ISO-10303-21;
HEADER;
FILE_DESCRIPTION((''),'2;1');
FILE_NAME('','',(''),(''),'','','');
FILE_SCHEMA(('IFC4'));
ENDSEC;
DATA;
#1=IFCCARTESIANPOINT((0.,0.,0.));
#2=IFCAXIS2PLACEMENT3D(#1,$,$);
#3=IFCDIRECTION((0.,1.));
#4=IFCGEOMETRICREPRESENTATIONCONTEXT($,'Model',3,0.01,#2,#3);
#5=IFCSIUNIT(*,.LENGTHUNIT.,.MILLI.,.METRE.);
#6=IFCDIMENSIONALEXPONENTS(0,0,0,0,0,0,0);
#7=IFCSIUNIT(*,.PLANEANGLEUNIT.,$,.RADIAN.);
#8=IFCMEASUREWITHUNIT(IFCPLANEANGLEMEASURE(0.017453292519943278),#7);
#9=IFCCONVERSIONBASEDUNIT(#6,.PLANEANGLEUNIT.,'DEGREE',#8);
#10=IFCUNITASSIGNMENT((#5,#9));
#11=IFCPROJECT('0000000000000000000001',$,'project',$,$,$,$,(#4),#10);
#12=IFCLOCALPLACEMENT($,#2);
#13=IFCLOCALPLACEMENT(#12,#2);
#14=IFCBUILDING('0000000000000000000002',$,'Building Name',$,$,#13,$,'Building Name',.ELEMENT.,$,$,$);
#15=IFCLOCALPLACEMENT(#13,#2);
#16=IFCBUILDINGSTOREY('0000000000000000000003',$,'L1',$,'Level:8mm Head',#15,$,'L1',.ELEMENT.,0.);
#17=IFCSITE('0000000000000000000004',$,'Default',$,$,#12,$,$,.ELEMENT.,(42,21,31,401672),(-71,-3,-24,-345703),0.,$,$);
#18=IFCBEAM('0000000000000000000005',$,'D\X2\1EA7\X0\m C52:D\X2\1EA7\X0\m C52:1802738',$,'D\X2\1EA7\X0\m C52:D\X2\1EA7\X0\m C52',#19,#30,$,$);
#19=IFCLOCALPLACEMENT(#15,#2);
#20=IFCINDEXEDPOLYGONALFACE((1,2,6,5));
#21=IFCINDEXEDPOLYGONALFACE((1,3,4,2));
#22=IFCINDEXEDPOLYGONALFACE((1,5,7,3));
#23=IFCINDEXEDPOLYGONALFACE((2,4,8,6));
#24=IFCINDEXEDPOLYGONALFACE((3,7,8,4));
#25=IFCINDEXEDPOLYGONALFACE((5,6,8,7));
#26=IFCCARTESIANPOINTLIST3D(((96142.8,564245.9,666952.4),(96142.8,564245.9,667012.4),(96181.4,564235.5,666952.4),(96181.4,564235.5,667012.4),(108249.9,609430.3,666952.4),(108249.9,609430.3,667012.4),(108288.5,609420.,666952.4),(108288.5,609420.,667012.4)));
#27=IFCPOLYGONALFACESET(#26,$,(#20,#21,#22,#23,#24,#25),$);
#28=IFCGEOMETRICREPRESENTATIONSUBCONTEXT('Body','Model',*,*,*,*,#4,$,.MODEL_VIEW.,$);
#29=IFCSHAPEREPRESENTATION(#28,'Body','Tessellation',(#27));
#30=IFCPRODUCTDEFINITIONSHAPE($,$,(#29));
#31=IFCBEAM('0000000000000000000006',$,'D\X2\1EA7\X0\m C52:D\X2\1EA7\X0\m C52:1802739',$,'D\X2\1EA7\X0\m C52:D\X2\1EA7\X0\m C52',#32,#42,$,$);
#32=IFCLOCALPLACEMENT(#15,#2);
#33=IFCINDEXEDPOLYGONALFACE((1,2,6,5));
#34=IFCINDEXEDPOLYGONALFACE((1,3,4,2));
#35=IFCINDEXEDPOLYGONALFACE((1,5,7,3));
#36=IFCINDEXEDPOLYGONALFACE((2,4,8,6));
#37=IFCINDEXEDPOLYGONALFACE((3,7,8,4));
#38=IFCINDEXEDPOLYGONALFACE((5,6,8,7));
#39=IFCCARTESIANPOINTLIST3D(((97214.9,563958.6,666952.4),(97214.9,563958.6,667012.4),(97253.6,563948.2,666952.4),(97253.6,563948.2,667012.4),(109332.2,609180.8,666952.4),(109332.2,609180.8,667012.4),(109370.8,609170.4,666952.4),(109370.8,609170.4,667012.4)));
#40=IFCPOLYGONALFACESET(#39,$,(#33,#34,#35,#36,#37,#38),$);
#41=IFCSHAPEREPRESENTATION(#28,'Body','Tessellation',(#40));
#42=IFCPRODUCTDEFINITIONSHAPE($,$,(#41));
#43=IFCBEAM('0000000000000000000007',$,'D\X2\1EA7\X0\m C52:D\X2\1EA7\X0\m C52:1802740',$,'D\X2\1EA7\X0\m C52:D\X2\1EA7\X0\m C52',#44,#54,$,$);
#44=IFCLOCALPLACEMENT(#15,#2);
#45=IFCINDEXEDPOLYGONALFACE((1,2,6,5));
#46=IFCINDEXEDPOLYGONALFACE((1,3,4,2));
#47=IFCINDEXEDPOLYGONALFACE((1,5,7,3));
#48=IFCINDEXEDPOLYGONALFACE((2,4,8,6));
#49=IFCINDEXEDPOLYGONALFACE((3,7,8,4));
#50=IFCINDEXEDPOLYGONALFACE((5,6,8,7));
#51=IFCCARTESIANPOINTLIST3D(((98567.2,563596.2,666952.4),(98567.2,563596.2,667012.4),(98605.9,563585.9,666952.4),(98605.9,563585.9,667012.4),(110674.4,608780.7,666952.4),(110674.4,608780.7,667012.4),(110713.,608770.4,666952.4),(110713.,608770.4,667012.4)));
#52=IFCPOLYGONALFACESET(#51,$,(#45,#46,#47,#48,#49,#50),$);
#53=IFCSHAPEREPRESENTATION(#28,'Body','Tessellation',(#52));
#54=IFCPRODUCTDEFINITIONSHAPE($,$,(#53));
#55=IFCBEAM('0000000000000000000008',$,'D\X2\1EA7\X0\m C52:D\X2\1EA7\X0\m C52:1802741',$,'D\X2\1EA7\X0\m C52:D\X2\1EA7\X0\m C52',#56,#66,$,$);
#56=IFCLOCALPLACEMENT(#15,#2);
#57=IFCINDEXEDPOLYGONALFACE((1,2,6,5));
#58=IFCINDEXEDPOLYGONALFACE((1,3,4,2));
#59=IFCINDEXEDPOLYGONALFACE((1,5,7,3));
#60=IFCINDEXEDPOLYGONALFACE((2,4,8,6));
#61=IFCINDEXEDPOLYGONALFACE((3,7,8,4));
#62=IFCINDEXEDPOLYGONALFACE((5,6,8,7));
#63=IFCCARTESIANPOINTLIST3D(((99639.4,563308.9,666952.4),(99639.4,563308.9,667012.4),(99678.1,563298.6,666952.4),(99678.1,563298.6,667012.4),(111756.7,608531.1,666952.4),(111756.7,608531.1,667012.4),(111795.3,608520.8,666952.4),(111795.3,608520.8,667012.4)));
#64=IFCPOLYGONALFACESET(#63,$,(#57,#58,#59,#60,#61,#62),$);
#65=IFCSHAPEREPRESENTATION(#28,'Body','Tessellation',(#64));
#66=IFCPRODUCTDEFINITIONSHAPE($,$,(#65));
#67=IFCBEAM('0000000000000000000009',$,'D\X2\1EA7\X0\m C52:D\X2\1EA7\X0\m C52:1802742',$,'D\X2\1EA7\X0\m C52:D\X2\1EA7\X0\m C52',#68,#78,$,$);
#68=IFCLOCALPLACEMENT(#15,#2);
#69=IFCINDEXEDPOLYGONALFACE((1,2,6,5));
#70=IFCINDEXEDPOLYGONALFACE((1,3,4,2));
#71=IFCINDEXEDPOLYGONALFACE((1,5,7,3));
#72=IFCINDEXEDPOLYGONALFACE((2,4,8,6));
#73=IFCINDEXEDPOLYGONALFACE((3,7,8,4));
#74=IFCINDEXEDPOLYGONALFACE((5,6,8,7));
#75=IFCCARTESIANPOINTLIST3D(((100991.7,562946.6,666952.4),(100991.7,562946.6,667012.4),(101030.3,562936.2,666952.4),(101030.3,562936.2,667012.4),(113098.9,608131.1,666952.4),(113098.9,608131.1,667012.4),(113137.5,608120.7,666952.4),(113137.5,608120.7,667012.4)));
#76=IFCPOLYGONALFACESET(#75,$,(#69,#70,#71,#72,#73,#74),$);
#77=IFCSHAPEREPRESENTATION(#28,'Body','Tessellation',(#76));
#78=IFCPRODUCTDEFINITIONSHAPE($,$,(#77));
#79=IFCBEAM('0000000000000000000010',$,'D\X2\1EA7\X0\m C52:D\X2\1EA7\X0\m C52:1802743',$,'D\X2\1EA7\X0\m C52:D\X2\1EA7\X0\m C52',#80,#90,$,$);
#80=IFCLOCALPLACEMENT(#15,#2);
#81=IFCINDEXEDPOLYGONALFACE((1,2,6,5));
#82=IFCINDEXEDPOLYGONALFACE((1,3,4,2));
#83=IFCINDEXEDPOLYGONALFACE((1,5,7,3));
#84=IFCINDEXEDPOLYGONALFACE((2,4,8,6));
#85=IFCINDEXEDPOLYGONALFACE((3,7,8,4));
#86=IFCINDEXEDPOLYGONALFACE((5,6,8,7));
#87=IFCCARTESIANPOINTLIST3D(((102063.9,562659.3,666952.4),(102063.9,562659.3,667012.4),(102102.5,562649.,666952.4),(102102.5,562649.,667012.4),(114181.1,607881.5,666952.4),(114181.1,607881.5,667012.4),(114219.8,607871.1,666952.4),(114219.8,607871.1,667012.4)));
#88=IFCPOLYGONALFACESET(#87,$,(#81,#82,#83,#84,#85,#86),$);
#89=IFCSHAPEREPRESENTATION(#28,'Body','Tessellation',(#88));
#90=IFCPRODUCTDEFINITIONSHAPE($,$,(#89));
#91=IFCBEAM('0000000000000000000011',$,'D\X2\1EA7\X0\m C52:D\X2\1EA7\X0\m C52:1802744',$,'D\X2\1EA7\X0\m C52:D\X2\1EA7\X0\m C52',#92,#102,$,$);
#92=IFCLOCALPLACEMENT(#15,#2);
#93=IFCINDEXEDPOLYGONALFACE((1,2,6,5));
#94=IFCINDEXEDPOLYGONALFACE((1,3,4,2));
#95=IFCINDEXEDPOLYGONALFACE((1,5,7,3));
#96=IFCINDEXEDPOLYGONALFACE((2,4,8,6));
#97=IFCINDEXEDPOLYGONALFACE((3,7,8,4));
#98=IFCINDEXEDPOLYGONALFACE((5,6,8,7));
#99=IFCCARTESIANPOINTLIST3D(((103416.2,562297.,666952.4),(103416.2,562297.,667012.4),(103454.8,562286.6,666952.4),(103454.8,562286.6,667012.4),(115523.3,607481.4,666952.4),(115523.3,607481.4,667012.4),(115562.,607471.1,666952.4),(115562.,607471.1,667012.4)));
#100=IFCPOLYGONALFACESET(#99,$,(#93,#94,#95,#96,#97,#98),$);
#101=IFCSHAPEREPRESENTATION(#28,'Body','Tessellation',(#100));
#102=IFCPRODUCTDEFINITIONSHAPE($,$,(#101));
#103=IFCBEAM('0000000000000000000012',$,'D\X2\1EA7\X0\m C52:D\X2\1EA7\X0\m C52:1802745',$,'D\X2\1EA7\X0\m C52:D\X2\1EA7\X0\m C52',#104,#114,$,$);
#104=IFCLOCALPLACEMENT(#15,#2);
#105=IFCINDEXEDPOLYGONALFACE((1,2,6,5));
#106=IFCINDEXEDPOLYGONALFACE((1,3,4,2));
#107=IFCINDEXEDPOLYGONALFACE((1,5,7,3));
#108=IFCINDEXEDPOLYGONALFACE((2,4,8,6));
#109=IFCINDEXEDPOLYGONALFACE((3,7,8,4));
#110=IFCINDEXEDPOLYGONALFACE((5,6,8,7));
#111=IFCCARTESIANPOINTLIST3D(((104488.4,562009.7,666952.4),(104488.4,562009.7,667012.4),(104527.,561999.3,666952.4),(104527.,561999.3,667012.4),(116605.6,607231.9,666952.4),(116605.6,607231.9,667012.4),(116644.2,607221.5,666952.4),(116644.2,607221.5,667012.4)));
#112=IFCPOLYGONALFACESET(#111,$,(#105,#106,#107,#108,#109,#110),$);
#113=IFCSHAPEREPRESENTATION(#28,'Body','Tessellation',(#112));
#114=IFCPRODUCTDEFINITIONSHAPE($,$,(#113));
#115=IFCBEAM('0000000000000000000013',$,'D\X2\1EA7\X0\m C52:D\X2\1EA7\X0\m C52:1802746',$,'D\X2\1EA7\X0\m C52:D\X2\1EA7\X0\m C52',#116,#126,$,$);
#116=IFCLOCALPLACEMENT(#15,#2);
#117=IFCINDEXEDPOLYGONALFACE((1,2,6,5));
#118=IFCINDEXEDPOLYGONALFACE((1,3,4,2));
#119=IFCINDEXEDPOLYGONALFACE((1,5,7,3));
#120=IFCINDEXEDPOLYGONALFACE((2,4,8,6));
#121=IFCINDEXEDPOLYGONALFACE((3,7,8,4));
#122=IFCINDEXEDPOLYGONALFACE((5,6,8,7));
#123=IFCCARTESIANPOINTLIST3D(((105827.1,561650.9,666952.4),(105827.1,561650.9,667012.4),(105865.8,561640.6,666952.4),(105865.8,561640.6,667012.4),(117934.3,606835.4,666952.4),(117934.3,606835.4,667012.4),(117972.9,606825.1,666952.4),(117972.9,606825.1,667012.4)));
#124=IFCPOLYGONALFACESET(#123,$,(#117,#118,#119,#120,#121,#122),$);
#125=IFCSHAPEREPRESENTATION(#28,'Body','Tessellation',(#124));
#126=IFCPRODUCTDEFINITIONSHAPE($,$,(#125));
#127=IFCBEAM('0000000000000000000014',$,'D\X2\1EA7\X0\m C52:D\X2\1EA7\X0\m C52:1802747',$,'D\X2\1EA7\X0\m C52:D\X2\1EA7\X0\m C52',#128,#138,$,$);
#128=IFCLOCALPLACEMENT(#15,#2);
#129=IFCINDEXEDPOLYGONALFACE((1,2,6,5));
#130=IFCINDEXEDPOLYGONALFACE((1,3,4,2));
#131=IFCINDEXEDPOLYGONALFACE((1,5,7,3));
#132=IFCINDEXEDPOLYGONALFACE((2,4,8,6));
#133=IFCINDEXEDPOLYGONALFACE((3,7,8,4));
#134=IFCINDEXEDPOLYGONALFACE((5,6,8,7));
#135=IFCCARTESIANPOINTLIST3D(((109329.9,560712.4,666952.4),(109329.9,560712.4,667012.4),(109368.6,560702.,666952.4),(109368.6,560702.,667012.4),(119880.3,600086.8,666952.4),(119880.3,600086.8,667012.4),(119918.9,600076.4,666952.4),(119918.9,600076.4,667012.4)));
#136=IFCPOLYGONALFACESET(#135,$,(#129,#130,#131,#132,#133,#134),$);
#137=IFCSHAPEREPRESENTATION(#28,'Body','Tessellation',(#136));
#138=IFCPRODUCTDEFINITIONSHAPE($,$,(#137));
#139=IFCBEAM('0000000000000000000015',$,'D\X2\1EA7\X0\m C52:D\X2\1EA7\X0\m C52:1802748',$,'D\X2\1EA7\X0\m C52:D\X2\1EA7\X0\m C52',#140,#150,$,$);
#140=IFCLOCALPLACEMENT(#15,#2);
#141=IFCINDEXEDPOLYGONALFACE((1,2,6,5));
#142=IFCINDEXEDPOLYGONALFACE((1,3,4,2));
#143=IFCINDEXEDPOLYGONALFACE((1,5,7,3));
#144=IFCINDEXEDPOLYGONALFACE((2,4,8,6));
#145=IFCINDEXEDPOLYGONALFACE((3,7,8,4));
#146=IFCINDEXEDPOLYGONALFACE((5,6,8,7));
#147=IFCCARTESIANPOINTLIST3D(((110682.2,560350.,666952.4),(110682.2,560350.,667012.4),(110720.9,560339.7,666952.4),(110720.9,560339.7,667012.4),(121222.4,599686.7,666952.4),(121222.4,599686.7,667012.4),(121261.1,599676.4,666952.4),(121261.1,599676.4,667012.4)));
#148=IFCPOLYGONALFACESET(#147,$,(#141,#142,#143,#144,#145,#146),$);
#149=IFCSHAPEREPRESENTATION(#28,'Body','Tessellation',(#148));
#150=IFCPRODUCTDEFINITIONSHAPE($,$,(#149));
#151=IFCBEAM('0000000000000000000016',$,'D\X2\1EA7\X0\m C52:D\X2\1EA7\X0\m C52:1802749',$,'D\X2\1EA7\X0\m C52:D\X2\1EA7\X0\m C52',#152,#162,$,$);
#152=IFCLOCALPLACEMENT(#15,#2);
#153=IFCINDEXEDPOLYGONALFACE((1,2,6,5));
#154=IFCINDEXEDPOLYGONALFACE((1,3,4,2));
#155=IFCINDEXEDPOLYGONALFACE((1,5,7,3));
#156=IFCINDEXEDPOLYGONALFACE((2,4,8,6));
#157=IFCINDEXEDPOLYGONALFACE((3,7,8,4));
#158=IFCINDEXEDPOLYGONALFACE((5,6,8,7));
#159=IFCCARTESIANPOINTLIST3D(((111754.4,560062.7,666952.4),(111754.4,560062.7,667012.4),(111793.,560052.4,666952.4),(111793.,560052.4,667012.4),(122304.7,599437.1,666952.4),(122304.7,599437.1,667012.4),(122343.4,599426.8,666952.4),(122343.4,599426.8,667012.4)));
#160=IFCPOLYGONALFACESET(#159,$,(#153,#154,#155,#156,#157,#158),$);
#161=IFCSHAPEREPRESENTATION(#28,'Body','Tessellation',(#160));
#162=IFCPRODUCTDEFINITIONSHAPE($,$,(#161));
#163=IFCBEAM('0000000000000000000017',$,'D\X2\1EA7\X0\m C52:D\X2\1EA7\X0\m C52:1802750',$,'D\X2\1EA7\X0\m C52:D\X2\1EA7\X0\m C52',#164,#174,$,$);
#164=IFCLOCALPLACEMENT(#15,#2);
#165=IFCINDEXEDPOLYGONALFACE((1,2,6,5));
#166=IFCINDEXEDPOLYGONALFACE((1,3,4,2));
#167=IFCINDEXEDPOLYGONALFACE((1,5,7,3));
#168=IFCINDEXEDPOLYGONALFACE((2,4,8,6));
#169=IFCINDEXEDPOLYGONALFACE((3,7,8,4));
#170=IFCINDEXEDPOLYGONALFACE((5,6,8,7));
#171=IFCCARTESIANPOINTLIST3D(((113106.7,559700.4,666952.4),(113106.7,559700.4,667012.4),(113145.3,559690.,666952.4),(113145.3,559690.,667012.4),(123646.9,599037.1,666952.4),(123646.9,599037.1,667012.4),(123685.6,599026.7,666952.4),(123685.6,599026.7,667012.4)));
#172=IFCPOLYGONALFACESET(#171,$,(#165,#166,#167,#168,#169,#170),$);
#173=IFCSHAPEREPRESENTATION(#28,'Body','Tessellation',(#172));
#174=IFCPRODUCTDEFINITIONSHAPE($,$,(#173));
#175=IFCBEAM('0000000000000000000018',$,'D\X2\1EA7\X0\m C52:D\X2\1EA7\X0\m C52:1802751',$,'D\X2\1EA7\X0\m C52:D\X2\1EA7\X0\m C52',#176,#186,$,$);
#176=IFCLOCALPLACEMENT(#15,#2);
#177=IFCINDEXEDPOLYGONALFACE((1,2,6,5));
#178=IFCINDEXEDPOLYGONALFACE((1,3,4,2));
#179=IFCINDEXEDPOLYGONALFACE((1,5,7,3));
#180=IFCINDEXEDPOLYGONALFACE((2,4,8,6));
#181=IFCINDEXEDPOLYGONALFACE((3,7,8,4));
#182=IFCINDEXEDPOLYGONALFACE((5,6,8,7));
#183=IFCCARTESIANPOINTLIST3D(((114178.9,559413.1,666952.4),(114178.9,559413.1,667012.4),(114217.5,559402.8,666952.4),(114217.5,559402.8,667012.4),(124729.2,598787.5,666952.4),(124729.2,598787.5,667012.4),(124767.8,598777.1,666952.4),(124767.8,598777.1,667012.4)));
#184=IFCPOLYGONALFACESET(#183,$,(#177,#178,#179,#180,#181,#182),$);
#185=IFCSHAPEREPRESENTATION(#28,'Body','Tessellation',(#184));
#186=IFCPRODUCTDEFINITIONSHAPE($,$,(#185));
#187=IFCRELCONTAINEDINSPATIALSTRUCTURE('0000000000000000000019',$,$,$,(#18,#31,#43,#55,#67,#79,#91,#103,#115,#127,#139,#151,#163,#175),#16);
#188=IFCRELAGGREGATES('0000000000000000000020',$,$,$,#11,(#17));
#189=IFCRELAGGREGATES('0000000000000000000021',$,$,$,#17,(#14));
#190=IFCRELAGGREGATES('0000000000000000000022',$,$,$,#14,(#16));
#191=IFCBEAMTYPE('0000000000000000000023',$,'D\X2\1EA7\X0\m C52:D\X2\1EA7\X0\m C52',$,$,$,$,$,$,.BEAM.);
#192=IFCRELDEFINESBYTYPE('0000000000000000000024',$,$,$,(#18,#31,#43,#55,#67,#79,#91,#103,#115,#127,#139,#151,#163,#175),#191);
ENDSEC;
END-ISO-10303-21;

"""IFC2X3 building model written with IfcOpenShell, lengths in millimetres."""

from ifc_helpers import new_model, entity, si_unit, converted_unit, direction, frame, frame_2d, origin, origin_2d_with_axis, place, context, subcontext, project, spatial, rectangle, extrude, type_object, element, save


model = new_model("IFC2X3")

# Units and contexts
model_context = context("Model", 3, precision=0.01, world=origin(), true_north=direction((0.0, 1.0)))
body_context = subcontext(model_context, "Body", "Model", "MODEL_VIEW")
ifc_project = project(units=[si_unit("LENGTHUNIT", "METRE", prefix="MILLI"), converted_unit("PLANEANGLEUNIT", "DEGREE", entity("IfcPlaneAngleMeasure", 0.017453292519943278), si_unit("PLANEANGLEUNIT", "RADIAN"), dimensions=[0, 0, 0, 0, 0, 0, 0])], contexts=[model_context])

# Site, building, storey
site_placement = place(None, origin())
site = spatial("IfcSite", under=ifc_project, at=site_placement, Name="Default", CompositionType="ELEMENT", RefLatitude=(42, 21, 31, 401672), RefLongitude=(-71, -3, -24, -345703), RefElevation=0.0)
building_placement = place(site_placement, origin())
building = spatial("IfcBuilding", under=site, at=building_placement, Name="Building Name", LongName="Building Name", CompositionType="ELEMENT")
storey_placement = place(building_placement, origin())
storey = spatial("IfcBuildingStorey", under=building, at=storey_placement, Name="L1", ObjectType="Level:8mm Head", LongName="L1", CompositionType="ELEMENT", Elevation=0.0)

# Beams
beam_type = type_object("IfcBeamType", Name="Dầm C52:Dầm C52", PredefinedType="BEAM")
beam_1_placement = place(storey_placement, frame((96162.1, 564240.7, 666862.4), z_axis=(0.0, 0.0, 1.0), x_axis=(0.258819, 0.965926, 0.0)))
element("IfcBeam", 1, at=beam_1_placement, inside=storey, type_object=beam_type, Name="Dầm C52:Dầm C52:1802738", ObjectType="Dầm C52:Dầm C52", context=body_context, shape_type="SweptSolid", body=[
    extrude(rectangle(XDim=60.0, YDim=40.0, at=origin_2d_with_axis()), frame((0.0, 0.0, 120.0), z_axis=(1.0, 0.0, 0.0), x_axis=(0.0, 0.0, -1.0)), (0.0, 0.0, 1.0), 46778.4),
])
beam_2_placement = place(storey_placement, frame((97234.3, 563953.4, 666862.4), z_axis=(0.0, 0.0, 1.0), x_axis=(0.258819, 0.965926, 0.0)))
element("IfcBeam", 2, at=beam_2_placement, inside=storey, type_object=beam_type, Name="Dầm C52:Dầm C52:1802739", ObjectType="Dầm C52:Dầm C52", context=body_context, shape_type="SweptSolid", body=[
    extrude(rectangle(XDim=60.0, YDim=40.0, at=frame_2d((0.0, 0.0), x_axis=(1.0, 0.0))), frame((0.0, 0.0, 120.0), z_axis=(1.0, 0.0, 0.0), x_axis=(0.0, 0.0, -1.0)), (0.0, 0.0, 1.0), 46817.5),
])
beam_3_placement = place(storey_placement, frame((98586.6, 563591.1, 666862.4), z_axis=(0.0, 0.0, 1.0), x_axis=(0.258819, 0.965926, 0.0)))
element("IfcBeam", 3, at=beam_3_placement, inside=storey, type_object=beam_type, Name="Dầm C52:Dầm C52:1802740", ObjectType="Dầm C52:Dầm C52", context=body_context, shape_type="SweptSolid", body=[
    extrude(rectangle(XDim=60.0, YDim=40.0, at=frame_2d((0.0, 0.0), x_axis=(1.0, 0.0))), frame((0.0, 0.0, 120.0), z_axis=(1.0, 0.0, 0.0), x_axis=(0.0, 0.0, -1.0)), (0.0, 0.0, 1.0), 46778.4),
])
beam_4_placement = place(storey_placement, frame((99658.7, 563303.8, 666862.4), z_axis=(0.0, 0.0, 1.0), x_axis=(0.258819, 0.965926, 0.0)))
element("IfcBeam", 4, at=beam_4_placement, inside=storey, type_object=beam_type, Name="Dầm C52:Dầm C52:1802741", ObjectType="Dầm C52:Dầm C52", context=body_context, shape_type="SweptSolid", body=[
    extrude(rectangle(XDim=60.0, YDim=40.0, at=frame_2d((0.0, 0.0), x_axis=(1.0, 0.0))), frame((0.0, 0.0, 120.0), z_axis=(1.0, 0.0, 0.0), x_axis=(0.0, 0.0, -1.0)), (0.0, 0.0, 1.0), 46817.5),
])
beam_5_placement = place(storey_placement, frame((101011.0, 562941.4, 666862.4), z_axis=(0.0, 0.0, 1.0), x_axis=(0.258819, 0.965926, 0.0)))
element("IfcBeam", 5, at=beam_5_placement, inside=storey, type_object=beam_type, Name="Dầm C52:Dầm C52:1802742", ObjectType="Dầm C52:Dầm C52", context=body_context, shape_type="SweptSolid", body=[
    extrude(rectangle(XDim=60.0, YDim=40.0, at=frame_2d((0.0, 0.0), x_axis=(1.0, 0.0))), frame((0.0, 0.0, 120.0), z_axis=(1.0, 0.0, 0.0), x_axis=(0.0, 0.0, -1.0)), (0.0, 0.0, 1.0), 46778.4),
])
beam_6_placement = place(storey_placement, frame((102083.2, 562654.1, 666862.4), z_axis=(0.0, 0.0, 1.0), x_axis=(0.258819, 0.965926, 0.0)))
element("IfcBeam", 6, at=beam_6_placement, inside=storey, type_object=beam_type, Name="Dầm C52:Dầm C52:1802743", ObjectType="Dầm C52:Dầm C52", context=body_context, shape_type="SweptSolid", body=[
    extrude(rectangle(XDim=60.0, YDim=40.0, at=frame_2d((0.0, 0.0), x_axis=(1.0, 0.0))), frame((0.0, 0.0, 120.0), z_axis=(1.0, 0.0, 0.0), x_axis=(0.0, 0.0, -1.0)), (0.0, 0.0, 1.0), 46817.5),
])
beam_7_placement = place(storey_placement, frame((103435.5, 562291.8, 666862.4), z_axis=(0.0, 0.0, 1.0), x_axis=(0.258819, 0.965926, 0.0)))
element("IfcBeam", 7, at=beam_7_placement, inside=storey, type_object=beam_type, Name="Dầm C52:Dầm C52:1802744", ObjectType="Dầm C52:Dầm C52", context=body_context, shape_type="SweptSolid", body=[
    extrude(rectangle(XDim=60.0, YDim=40.0, at=frame_2d((0.0, 0.0), x_axis=(1.0, 0.0))), frame((0.0, 0.0, 120.0), z_axis=(1.0, 0.0, 0.0), x_axis=(0.0, 0.0, -1.0)), (0.0, 0.0, 1.0), 46778.4),
])
beam_8_placement = place(storey_placement, frame((104507.7, 562004.5, 666862.4), z_axis=(0.0, 0.0, 1.0), x_axis=(0.258819, 0.965926, 0.0)))
element("IfcBeam", 8, at=beam_8_placement, inside=storey, type_object=beam_type, Name="Dầm C52:Dầm C52:1802745", ObjectType="Dầm C52:Dầm C52", context=body_context, shape_type="SweptSolid", body=[
    extrude(rectangle(XDim=60.0, YDim=40.0, at=origin_2d_with_axis()), frame((0.0, 0.0, 120.0), z_axis=(1.0, 0.0, 0.0), x_axis=(0.0, 0.0, -1.0)), (0.0, 0.0, 1.0), 46817.5),
])
beam_9_placement = place(storey_placement, frame((105846.4, 561645.8, 666862.4), z_axis=(0.0, 0.0, 1.0), x_axis=(0.258819, 0.965926, 0.0)))
element("IfcBeam", 9, at=beam_9_placement, inside=storey, type_object=beam_type, Name="Dầm C52:Dầm C52:1802746", ObjectType="Dầm C52:Dầm C52", context=body_context, shape_type="SweptSolid", body=[
    extrude(rectangle(XDim=60.0, YDim=40.0, at=origin_2d_with_axis()), frame((0.0, 0.0, 120.0), z_axis=(1.0, 0.0, 0.0), x_axis=(0.0, 0.0, -1.0)), (0.0, 0.0, 1.0), 46778.4),
])
beam_10_placement = place(storey_placement, frame((109349.2, 560707.2, 666862.4), z_axis=(0.0, 0.0, 1.0), x_axis=(0.258819, 0.965926, 0.0)))
element("IfcBeam", 10, at=beam_10_placement, inside=storey, type_object=beam_type, Name="Dầm C52:Dầm C52:1802747", ObjectType="Dầm C52:Dầm C52", context=body_context, shape_type="SweptSolid", body=[
    extrude(rectangle(XDim=60.0, YDim=40.0, at=frame_2d((0.0, 0.0), x_axis=(1.0, 0.0))), frame((0.0, 0.0, 120.0), z_axis=(1.0, 0.0, 0.0), x_axis=(0.0, 0.0, -1.0)), (0.0, 0.0, 1.0), 40763.4),
])
beam_11_placement = place(storey_placement, frame((110701.5, 560344.9, 666862.4), z_axis=(0.0, 0.0, 1.0), x_axis=(0.258819, 0.965926, 0.0)))
element("IfcBeam", 11, at=beam_11_placement, inside=storey, type_object=beam_type, Name="Dầm C52:Dầm C52:1802748", ObjectType="Dầm C52:Dầm C52", context=body_context, shape_type="SweptSolid", body=[
    extrude(rectangle(XDim=60.0, YDim=40.0, at=frame_2d((0.0, 0.0), x_axis=(1.0, 0.0))), frame((0.0, 0.0, 120.0), z_axis=(1.0, 0.0, 0.0), x_axis=(0.0, 0.0, -1.0)), (0.0, 0.0, 1.0), 40724.3),
])
beam_12_placement = place(storey_placement, frame((111773.7, 560057.6, 666862.4), z_axis=(0.0, 0.0, 1.0), x_axis=(0.258819, 0.965926, 0.0)))
element("IfcBeam", 12, at=beam_12_placement, inside=storey, type_object=beam_type, Name="Dầm C52:Dầm C52:1802749", ObjectType="Dầm C52:Dầm C52", context=body_context, shape_type="SweptSolid", body=[
    extrude(rectangle(XDim=60.0, YDim=40.0, at=origin_2d_with_axis()), frame((0.0, 0.0, 120.0), z_axis=(1.0, 0.0, 0.0), x_axis=(0.0, 0.0, -1.0)), (0.0, 0.0, 1.0), 40763.4),
])
beam_13_placement = place(storey_placement, frame((113126.0, 559695.2, 666862.4), z_axis=(0.0, 0.0, 1.0), x_axis=(0.258819, 0.965926, 0.0)))
element("IfcBeam", 13, at=beam_13_placement, inside=storey, type_object=beam_type, Name="Dầm C52:Dầm C52:1802750", ObjectType="Dầm C52:Dầm C52", context=body_context, shape_type="SweptSolid", body=[
    extrude(rectangle(XDim=60.0, YDim=40.0, at=frame_2d((0.0, 0.0), x_axis=(1.0, 0.0))), frame((0.0, 0.0, 120.0), z_axis=(1.0, 0.0, 0.0), x_axis=(0.0, 0.0, -1.0)), (0.0, 0.0, 1.0), 40724.3),
])
beam_14_placement = place(storey_placement, frame((114198.2, 559407.9, 666862.4), z_axis=(0.0, 0.0, 1.0), x_axis=(0.258819, 0.965926, 0.0)))
element("IfcBeam", 14, at=beam_14_placement, inside=storey, type_object=beam_type, Name="Dầm C52:Dầm C52:1802751", ObjectType="Dầm C52:Dầm C52", context=body_context, shape_type="SweptSolid", body=[
    extrude(rectangle(XDim=60.0, YDim=40.0, at=origin_2d_with_axis()), frame((0.0, 0.0, 120.0), z_axis=(1.0, 0.0, 0.0), x_axis=(0.0, 0.0, -1.0)), (0.0, 0.0, 1.0), 40763.4),
])

save(model, "model.ifc")
